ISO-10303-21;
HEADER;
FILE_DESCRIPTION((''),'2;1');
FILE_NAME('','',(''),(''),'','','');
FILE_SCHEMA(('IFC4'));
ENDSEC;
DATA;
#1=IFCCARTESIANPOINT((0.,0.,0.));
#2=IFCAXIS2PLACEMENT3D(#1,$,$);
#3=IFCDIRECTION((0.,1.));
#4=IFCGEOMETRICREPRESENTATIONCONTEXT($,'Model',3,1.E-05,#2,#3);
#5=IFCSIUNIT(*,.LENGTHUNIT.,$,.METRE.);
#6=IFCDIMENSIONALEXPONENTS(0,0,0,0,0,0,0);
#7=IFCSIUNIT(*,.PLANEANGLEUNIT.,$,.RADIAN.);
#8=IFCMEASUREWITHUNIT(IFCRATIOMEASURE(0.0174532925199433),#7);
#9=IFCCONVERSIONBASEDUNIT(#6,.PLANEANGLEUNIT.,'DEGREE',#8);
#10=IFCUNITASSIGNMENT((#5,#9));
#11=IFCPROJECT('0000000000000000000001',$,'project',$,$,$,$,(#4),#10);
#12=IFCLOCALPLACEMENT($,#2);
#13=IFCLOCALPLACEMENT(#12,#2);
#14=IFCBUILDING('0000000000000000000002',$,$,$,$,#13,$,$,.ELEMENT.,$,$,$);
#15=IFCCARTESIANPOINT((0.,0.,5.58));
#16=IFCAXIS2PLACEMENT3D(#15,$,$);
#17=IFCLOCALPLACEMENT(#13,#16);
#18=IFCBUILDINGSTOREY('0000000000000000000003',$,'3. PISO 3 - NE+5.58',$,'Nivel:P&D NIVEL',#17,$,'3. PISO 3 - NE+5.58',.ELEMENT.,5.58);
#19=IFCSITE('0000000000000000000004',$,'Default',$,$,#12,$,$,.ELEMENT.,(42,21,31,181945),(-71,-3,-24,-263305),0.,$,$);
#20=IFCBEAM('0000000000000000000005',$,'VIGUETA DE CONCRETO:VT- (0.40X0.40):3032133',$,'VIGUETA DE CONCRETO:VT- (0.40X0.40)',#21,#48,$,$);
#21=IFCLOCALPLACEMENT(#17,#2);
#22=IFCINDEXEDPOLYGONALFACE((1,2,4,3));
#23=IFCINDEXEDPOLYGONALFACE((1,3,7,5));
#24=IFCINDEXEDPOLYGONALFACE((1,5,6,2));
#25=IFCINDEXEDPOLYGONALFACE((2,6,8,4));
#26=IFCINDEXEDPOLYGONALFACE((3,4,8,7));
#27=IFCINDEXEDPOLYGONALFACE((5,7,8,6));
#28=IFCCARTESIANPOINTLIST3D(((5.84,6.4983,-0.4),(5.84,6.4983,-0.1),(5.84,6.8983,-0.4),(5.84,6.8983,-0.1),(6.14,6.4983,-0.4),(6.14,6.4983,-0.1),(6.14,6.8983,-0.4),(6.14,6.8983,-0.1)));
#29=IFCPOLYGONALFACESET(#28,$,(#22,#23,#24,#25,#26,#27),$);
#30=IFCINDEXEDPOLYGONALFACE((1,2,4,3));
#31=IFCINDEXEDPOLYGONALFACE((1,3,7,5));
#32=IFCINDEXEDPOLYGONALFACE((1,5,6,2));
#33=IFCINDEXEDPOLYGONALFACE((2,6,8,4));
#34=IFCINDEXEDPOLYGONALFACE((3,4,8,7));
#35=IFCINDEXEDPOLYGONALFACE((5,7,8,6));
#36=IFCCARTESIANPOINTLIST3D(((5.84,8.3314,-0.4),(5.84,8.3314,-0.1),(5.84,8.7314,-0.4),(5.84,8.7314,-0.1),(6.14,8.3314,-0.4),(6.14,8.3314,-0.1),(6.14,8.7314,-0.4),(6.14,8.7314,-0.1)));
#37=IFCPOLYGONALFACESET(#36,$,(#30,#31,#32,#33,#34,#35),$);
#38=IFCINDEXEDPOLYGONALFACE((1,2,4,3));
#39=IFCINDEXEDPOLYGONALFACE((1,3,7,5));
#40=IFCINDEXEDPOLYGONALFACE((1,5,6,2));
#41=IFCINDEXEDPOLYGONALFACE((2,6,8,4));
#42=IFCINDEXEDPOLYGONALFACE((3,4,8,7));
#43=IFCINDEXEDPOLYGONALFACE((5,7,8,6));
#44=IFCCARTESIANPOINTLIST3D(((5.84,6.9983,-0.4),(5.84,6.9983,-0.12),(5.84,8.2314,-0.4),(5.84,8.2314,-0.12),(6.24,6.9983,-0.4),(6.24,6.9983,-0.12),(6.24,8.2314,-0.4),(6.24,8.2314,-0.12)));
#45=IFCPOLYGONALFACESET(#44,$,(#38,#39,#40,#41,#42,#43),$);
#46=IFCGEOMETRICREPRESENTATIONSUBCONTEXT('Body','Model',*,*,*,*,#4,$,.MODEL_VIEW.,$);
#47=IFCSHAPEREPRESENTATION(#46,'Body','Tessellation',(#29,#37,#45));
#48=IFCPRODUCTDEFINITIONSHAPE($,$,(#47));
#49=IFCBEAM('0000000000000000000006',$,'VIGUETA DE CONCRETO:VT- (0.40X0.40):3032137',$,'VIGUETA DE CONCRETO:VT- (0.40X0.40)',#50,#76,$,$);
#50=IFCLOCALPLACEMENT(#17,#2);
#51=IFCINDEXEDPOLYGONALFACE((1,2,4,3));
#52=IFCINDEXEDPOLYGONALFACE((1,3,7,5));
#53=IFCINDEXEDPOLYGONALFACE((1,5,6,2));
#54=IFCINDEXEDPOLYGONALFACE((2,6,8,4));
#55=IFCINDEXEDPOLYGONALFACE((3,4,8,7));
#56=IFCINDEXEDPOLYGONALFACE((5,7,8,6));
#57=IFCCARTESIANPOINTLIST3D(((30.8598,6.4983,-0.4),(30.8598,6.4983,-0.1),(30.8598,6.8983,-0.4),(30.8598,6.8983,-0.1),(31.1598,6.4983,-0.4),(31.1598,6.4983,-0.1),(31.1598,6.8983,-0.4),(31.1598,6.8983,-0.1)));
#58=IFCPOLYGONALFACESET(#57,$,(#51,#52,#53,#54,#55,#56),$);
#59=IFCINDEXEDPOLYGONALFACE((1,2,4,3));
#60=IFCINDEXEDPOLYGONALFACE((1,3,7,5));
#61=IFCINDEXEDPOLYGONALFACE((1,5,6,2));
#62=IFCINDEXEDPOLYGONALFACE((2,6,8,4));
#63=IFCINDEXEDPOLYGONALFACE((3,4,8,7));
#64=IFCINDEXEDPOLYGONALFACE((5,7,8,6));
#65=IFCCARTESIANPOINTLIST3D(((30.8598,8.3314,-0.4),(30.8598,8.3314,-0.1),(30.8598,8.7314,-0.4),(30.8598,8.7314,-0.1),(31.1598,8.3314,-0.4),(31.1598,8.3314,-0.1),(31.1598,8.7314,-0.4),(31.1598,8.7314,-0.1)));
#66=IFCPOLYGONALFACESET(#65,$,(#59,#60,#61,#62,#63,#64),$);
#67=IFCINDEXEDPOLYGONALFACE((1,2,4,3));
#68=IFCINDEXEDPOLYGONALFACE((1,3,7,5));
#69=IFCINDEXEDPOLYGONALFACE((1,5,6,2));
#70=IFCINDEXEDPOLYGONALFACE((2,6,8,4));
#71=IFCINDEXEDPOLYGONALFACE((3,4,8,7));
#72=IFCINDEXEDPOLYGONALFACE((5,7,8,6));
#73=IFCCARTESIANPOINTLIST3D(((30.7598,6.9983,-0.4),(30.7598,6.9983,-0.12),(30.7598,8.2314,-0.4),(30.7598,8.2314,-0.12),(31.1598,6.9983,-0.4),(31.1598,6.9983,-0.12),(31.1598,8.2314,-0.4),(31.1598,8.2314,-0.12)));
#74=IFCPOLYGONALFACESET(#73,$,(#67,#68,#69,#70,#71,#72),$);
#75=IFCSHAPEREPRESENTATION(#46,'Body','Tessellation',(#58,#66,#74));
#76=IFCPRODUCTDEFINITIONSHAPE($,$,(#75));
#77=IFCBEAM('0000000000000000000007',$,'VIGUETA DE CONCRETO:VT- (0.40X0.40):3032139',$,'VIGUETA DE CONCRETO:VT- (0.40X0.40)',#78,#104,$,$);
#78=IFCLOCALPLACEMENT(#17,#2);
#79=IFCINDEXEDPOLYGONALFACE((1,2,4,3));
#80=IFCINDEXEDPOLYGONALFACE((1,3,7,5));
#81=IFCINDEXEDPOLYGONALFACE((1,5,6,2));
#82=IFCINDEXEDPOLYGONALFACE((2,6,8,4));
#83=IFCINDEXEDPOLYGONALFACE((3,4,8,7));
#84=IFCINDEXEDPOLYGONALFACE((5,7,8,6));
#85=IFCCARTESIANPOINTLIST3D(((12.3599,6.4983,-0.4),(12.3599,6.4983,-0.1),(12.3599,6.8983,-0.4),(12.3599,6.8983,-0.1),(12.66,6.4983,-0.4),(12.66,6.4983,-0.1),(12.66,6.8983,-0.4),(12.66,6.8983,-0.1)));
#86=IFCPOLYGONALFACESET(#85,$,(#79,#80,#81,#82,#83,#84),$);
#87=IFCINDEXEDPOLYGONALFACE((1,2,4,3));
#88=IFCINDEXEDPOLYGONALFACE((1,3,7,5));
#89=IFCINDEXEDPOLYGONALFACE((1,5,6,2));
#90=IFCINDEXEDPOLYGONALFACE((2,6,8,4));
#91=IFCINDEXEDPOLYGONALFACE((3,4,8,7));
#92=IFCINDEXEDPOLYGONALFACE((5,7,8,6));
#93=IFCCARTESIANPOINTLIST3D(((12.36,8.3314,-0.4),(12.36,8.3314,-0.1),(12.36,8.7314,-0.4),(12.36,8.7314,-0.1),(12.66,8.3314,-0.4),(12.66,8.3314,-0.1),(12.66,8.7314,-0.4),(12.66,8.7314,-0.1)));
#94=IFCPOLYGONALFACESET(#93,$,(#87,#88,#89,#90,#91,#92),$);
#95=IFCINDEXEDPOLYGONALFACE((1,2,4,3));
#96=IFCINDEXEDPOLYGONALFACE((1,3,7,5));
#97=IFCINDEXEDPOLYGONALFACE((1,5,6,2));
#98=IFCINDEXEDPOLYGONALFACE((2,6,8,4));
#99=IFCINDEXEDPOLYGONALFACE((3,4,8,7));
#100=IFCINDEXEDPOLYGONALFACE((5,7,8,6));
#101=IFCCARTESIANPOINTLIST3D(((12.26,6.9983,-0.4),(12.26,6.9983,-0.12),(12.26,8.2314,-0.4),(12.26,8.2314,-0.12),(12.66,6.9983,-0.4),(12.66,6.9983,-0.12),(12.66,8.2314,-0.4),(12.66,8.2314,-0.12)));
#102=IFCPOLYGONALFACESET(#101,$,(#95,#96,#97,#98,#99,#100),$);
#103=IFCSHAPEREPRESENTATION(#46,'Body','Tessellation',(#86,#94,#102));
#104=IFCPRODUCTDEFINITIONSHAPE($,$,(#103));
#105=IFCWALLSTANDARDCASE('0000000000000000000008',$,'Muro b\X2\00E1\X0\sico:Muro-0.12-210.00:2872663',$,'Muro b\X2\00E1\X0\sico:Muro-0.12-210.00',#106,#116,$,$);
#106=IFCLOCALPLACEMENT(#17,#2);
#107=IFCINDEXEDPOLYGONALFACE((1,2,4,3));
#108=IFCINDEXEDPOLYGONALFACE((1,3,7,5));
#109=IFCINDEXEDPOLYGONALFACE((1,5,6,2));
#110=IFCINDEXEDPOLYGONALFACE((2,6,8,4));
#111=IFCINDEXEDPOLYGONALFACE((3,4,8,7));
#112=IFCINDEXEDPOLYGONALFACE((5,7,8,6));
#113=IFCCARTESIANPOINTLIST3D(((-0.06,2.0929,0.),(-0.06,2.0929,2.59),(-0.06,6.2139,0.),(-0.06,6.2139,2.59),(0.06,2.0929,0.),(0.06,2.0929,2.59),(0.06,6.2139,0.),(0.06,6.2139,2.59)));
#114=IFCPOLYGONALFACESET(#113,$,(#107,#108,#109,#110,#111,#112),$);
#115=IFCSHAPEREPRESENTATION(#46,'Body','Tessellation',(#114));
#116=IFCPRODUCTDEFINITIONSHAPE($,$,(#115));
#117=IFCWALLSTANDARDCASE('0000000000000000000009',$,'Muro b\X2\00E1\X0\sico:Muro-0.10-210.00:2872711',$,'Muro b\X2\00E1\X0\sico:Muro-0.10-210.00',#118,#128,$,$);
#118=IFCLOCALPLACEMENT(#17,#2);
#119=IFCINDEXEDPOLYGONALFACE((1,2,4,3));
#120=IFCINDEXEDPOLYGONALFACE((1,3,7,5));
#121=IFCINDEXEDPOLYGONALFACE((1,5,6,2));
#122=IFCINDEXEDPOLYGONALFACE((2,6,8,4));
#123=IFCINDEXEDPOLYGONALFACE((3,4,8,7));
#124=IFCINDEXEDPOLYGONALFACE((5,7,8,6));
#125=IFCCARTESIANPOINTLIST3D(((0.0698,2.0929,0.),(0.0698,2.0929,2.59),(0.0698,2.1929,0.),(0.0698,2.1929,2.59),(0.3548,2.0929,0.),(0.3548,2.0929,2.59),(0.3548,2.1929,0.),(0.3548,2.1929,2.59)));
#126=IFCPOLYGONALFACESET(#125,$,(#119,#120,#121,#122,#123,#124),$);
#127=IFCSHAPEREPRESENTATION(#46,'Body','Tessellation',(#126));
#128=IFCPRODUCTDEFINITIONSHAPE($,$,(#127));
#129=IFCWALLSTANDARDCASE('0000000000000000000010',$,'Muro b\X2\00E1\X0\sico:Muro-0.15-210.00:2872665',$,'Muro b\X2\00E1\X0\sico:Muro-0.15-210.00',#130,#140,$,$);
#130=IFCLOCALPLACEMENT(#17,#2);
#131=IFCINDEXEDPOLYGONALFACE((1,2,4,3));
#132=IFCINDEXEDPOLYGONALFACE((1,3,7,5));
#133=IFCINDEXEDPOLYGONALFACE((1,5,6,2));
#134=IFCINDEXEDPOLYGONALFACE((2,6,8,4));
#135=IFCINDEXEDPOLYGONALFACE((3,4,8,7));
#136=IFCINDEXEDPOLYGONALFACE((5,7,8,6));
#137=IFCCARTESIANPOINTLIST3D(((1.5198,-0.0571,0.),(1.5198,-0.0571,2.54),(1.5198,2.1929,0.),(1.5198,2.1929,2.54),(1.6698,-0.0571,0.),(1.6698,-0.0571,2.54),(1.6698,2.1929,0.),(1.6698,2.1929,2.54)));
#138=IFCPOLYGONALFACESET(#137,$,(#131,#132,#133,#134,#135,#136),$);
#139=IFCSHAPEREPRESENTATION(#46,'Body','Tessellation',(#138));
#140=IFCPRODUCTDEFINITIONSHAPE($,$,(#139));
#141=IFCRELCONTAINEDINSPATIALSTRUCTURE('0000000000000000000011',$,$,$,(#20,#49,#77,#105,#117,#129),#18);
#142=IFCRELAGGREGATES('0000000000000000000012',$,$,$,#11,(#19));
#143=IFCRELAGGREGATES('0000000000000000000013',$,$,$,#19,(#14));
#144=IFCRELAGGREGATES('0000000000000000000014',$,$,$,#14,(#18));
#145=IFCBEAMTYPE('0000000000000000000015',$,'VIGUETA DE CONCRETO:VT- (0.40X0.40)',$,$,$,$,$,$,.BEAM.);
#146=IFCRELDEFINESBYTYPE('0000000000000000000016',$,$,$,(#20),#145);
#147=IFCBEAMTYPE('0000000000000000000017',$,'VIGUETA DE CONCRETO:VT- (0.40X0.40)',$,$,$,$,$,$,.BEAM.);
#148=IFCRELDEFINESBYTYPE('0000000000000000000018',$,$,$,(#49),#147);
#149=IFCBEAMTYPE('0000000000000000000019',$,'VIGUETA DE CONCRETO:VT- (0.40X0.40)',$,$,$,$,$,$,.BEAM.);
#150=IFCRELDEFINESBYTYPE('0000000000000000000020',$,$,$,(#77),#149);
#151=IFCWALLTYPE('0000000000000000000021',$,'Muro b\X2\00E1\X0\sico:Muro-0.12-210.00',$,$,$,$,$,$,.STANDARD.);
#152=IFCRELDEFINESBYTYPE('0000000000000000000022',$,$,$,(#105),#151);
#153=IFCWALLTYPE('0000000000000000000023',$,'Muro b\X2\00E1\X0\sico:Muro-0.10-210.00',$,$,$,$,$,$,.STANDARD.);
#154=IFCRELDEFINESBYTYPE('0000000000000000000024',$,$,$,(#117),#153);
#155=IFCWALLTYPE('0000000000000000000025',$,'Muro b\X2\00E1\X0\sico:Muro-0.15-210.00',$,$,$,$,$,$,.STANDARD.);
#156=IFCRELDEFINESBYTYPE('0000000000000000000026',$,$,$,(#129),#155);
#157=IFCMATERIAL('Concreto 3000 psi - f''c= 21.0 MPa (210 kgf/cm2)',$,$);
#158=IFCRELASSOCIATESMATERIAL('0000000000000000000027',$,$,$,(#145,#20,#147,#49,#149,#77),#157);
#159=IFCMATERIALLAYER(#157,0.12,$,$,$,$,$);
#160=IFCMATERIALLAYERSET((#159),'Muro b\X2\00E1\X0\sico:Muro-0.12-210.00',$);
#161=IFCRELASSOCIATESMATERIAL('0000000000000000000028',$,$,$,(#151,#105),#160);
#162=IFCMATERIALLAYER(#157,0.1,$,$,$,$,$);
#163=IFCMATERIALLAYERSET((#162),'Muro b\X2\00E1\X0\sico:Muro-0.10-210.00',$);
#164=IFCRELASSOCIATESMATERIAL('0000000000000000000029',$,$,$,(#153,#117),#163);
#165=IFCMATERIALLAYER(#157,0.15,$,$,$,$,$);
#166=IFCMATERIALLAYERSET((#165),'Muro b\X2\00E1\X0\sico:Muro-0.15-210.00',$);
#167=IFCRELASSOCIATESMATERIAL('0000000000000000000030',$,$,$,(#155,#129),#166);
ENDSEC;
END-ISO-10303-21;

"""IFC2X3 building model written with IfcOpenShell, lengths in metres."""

from ifc_helpers import new_model, entity, si_unit, converted_unit, direction, frame, frame_2d, origin, place, context, subcontext, project, spatial, rectangle, extrude, source, transform, mapped, material, layer, layer_set, layer_usage, type_object, type_shapes, element, save


model = new_model("IFC2X3")

# Units and contexts
model_context = context("Model", 3, precision=1e-05, world=origin(), true_north=direction((0.0, 1.0)))
body_context = subcontext(model_context, "Body", "Model", "MODEL_VIEW")
ifc_project = project(units=[si_unit("LENGTHUNIT", "METRE"), converted_unit("PLANEANGLEUNIT", "DEGREE", entity("IfcRatioMeasure", 0.0174532925199433), si_unit("PLANEANGLEUNIT", "RADIAN"), dimensions=[0, 0, 0, 0, 0, 0, 0])], contexts=[model_context])

# Site, building, storey
site_placement = place(None, origin())
site = spatial("IfcSite", under=ifc_project, at=site_placement, Name="Default", CompositionType="ELEMENT", RefLatitude=(42, 21, 31, 181945), RefLongitude=(-71, -3, -24, -263305), RefElevation=0.0)
building_placement = place(site_placement, origin())
building = spatial("IfcBuilding", under=site, at=building_placement, CompositionType="ELEMENT")
storey_placement = place(building_placement, frame((0.0, 0.0, 5.58)))
storey = spatial("IfcBuildingStorey", under=building, at=storey_placement, Name="3. PISO 3 - NE+5.58", ObjectType="Nivel:P&D NIVEL", LongName="3. PISO 3 - NE+5.58", CompositionType="ELEMENT", Elevation=5.58)

# Beams
ifc_material = material(Name="Concreto 3000 psi - f'c= 21.0 MPa (210 kgf/cm2)")
beam_type_1 = type_object("IfcBeamType", Name="VIGUETA DE CONCRETO:VT- (0.40X0.40)", PredefinedType="BEAM", material=ifc_material)
shared_shape_1 = source(origin(), body_context, "Body", "SweptSolid", [
    extrude(rectangle(XDim=0.3, YDim=0.3, at=frame_2d((0.0, 0.0), x_axis=(0.0, 1.0))), frame((5.99, 6.8983, 5.33), z_axis=(0.0, -1.0, 0.0), x_axis=(-1.0, 0.0, 0.0)), (0.0, 0.0, 1.0), 0.4),
    extrude(rectangle(XDim=0.3, YDim=0.3, at=frame_2d((0.0, 0.0), x_axis=(0.0, 1.0))), frame((5.99, 8.7314, 5.33), z_axis=(0.0, -1.0, 0.0), x_axis=(-1.0, 0.0, 0.0)), (0.0, 0.0, 1.0), 0.4),
    extrude(rectangle(XDim=0.28, YDim=0.4, at=frame_2d((0.0, 0.0), x_axis=(0.0, 1.0))), frame((6.04, 8.2314, 5.32), z_axis=(0.0, -1.0, 0.0), x_axis=(-1.0, 0.0, 0.0)), (0.0, 0.0, 1.0), 1.2331),
])
type_shapes(beam_type_1, [shared_shape_1])
beam_1_placement = place(storey_placement, frame((0.0, 0.0, -5.58)))
element("IfcBeam", 1, at=beam_1_placement, inside=storey, type_object=beam_type_1, material=ifc_material, Name="VIGUETA DE CONCRETO:VT- (0.40X0.40):3032133", ObjectType="VIGUETA DE CONCRETO:VT- (0.40X0.40)", context=body_context, shape_type="MappedRepresentation", body=[
    mapped(shared_shape_1, transform((0.0, 0.0, 0.0), scale=1.0)),
])
beam_type_2 = type_object("IfcBeamType", Name="VIGUETA DE CONCRETO:VT- (0.40X0.40)", PredefinedType="BEAM", material=ifc_material)
shared_shape_2 = source(origin(), body_context, "Body", "SweptSolid", [
    extrude(rectangle(XDim=0.3, YDim=0.3, at=frame_2d((0.0, 0.0), x_axis=(0.0, 1.0))), frame((31.0098, 6.8983, 5.33), z_axis=(0.0, -1.0, 0.0), x_axis=(-1.0, 0.0, 0.0)), (0.0, 0.0, 1.0), 0.4),
    extrude(rectangle(XDim=0.3, YDim=0.3, at=frame_2d((0.0, 0.0), x_axis=(0.0, 1.0))), frame((31.0098, 8.7314, 5.33), z_axis=(0.0, -1.0, 0.0), x_axis=(-1.0, 0.0, 0.0)), (0.0, 0.0, 1.0), 0.4),
    extrude(rectangle(XDim=0.28, YDim=0.4, at=frame_2d((0.0, 0.0), x_axis=(0.0, 1.0))), frame((30.9598, 8.2314, 5.32), z_axis=(0.0, -1.0, 0.0), x_axis=(-1.0, 0.0, 0.0)), (0.0, 0.0, 1.0), 1.2331),
])
type_shapes(beam_type_2, [shared_shape_2])
beam_2_placement = place(storey_placement, frame((0.0, 0.0, -5.58)))
element("IfcBeam", 2, at=beam_2_placement, inside=storey, type_object=beam_type_2, material=ifc_material, Name="VIGUETA DE CONCRETO:VT- (0.40X0.40):3032137", ObjectType="VIGUETA DE CONCRETO:VT- (0.40X0.40)", context=body_context, shape_type="MappedRepresentation", body=[
    mapped(shared_shape_2, transform((0.0, 0.0, 0.0), scale=1.0)),
])
beam_type_3 = type_object("IfcBeamType", Name="VIGUETA DE CONCRETO:VT- (0.40X0.40)", PredefinedType="BEAM", material=ifc_material)
shared_shape_3 = source(origin(), body_context, "Body", "SweptSolid", [
    extrude(rectangle(XDim=0.3, YDim=0.3001, at=frame_2d((0.0, 0.0), x_axis=(0.0, 1.0))), frame((12.51, 6.8983, 5.33), z_axis=(0.0, -1.0, 0.0), x_axis=(-1.0, 0.0, 0.0)), (0.0, 0.0, 1.0), 0.4),
    extrude(rectangle(XDim=0.3, YDim=0.3, at=frame_2d((0.0, 0.0), x_axis=(0.0, 1.0))), frame((12.51, 8.7314, 5.33), z_axis=(0.0, -1.0, 0.0), x_axis=(-1.0, 0.0, 0.0)), (0.0, 0.0, 1.0), 0.4),
    extrude(rectangle(XDim=0.28, YDim=0.4, at=frame_2d((0.0, 0.0), x_axis=(0.0, 1.0))), frame((12.46, 8.2314, 5.32), z_axis=(0.0, -1.0, 0.0), x_axis=(-1.0, 0.0, 0.0)), (0.0, 0.0, 1.0), 1.2331),
])
type_shapes(beam_type_3, [shared_shape_3])
beam_3_placement = place(storey_placement, frame((0.0, 0.0, -5.58)))
element("IfcBeam", 3, at=beam_3_placement, inside=storey, type_object=beam_type_3, material=ifc_material, Name="VIGUETA DE CONCRETO:VT- (0.40X0.40):3032139", ObjectType="VIGUETA DE CONCRETO:VT- (0.40X0.40)", context=body_context, shape_type="MappedRepresentation", body=[
    mapped(shared_shape_3, transform((0.0, 0.0, 0.0), scale=1.0)),
])

# Walls
ifc_layer_1 = layer(ifc_material, 0.12)
ifc_layer_set_1 = layer_set([ifc_layer_1], Name="Muro básico:Muro-0.12-210.00")
ifc_layer_usage_1 = layer_usage(ifc_layer_set_1, "AXIS2", "POSITIVE", -0.06)
wall_type_1 = type_object("IfcWallType", Name="Muro básico:Muro-0.12-210.00", PredefinedType="STANDARD", material=ifc_layer_set_1)
wall_1_placement = place(storey_placement, frame((0.0, 2.0929, 0.0), z_axis=(0.0, 0.0, 1.0), x_axis=(0.0, 1.0, 0.0)))
element("IfcWallStandardCase", 4, at=wall_1_placement, inside=storey, type_object=wall_type_1, material=ifc_layer_usage_1, Name="Muro básico:Muro-0.12-210.00:2872663", ObjectType="Muro básico:Muro-0.12-210.00", context=body_context, shape_type="SweptSolid", body=[
    extrude(rectangle(XDim=4.121, YDim=0.12, at=frame_2d((2.0605, 0.0), x_axis=(-1.0, 0.0))), origin(), (0.0, 0.0, 1.0), 2.59),
])
ifc_layer_2 = layer(ifc_material, 0.1)
ifc_layer_set_2 = layer_set([ifc_layer_2], Name="Muro básico:Muro-0.10-210.00")
ifc_layer_usage_2 = layer_usage(ifc_layer_set_2, "AXIS2", "POSITIVE", -0.05)
wall_type_2 = type_object("IfcWallType", Name="Muro básico:Muro-0.10-210.00", PredefinedType="STANDARD", material=ifc_layer_set_2)
wall_2_placement = place(storey_placement, frame((0.0698, 2.1429, 0.0)))
element("IfcWallStandardCase", 5, at=wall_2_placement, inside=storey, type_object=wall_type_2, material=ifc_layer_usage_2, Name="Muro básico:Muro-0.10-210.00:2872711", ObjectType="Muro básico:Muro-0.10-210.00", context=body_context, shape_type="SweptSolid", body=[
    extrude(rectangle(XDim=0.285, YDim=0.1, at=frame_2d((0.1425, 0.0), x_axis=(-1.0, 0.0))), origin(), (0.0, 0.0, 1.0), 2.59),
])
ifc_layer_3 = layer(ifc_material, 0.15)
ifc_layer_set_3 = layer_set([ifc_layer_3], Name="Muro básico:Muro-0.15-210.00")
ifc_layer_usage_3 = layer_usage(ifc_layer_set_3, "AXIS2", "POSITIVE", -0.075)
wall_type_3 = type_object("IfcWallType", Name="Muro básico:Muro-0.15-210.00", PredefinedType="STANDARD", material=ifc_layer_set_3)
wall_3_placement = place(storey_placement, frame((1.5948, -0.0571, 0.0), z_axis=(0.0, 0.0, 1.0), x_axis=(0.0, 1.0, 0.0)))
element("IfcWallStandardCase", 6, at=wall_3_placement, inside=storey, type_object=wall_type_3, material=ifc_layer_usage_3, Name="Muro básico:Muro-0.15-210.00:2872665", ObjectType="Muro básico:Muro-0.15-210.00", context=body_context, shape_type="SweptSolid", body=[
    extrude(rectangle(XDim=2.25, YDim=0.15, at=frame_2d((1.125, 0.0), x_axis=(-1.0, 0.0))), origin(), (0.0, 0.0, 1.0), 2.54),
])

save(model, "model.ifc")
